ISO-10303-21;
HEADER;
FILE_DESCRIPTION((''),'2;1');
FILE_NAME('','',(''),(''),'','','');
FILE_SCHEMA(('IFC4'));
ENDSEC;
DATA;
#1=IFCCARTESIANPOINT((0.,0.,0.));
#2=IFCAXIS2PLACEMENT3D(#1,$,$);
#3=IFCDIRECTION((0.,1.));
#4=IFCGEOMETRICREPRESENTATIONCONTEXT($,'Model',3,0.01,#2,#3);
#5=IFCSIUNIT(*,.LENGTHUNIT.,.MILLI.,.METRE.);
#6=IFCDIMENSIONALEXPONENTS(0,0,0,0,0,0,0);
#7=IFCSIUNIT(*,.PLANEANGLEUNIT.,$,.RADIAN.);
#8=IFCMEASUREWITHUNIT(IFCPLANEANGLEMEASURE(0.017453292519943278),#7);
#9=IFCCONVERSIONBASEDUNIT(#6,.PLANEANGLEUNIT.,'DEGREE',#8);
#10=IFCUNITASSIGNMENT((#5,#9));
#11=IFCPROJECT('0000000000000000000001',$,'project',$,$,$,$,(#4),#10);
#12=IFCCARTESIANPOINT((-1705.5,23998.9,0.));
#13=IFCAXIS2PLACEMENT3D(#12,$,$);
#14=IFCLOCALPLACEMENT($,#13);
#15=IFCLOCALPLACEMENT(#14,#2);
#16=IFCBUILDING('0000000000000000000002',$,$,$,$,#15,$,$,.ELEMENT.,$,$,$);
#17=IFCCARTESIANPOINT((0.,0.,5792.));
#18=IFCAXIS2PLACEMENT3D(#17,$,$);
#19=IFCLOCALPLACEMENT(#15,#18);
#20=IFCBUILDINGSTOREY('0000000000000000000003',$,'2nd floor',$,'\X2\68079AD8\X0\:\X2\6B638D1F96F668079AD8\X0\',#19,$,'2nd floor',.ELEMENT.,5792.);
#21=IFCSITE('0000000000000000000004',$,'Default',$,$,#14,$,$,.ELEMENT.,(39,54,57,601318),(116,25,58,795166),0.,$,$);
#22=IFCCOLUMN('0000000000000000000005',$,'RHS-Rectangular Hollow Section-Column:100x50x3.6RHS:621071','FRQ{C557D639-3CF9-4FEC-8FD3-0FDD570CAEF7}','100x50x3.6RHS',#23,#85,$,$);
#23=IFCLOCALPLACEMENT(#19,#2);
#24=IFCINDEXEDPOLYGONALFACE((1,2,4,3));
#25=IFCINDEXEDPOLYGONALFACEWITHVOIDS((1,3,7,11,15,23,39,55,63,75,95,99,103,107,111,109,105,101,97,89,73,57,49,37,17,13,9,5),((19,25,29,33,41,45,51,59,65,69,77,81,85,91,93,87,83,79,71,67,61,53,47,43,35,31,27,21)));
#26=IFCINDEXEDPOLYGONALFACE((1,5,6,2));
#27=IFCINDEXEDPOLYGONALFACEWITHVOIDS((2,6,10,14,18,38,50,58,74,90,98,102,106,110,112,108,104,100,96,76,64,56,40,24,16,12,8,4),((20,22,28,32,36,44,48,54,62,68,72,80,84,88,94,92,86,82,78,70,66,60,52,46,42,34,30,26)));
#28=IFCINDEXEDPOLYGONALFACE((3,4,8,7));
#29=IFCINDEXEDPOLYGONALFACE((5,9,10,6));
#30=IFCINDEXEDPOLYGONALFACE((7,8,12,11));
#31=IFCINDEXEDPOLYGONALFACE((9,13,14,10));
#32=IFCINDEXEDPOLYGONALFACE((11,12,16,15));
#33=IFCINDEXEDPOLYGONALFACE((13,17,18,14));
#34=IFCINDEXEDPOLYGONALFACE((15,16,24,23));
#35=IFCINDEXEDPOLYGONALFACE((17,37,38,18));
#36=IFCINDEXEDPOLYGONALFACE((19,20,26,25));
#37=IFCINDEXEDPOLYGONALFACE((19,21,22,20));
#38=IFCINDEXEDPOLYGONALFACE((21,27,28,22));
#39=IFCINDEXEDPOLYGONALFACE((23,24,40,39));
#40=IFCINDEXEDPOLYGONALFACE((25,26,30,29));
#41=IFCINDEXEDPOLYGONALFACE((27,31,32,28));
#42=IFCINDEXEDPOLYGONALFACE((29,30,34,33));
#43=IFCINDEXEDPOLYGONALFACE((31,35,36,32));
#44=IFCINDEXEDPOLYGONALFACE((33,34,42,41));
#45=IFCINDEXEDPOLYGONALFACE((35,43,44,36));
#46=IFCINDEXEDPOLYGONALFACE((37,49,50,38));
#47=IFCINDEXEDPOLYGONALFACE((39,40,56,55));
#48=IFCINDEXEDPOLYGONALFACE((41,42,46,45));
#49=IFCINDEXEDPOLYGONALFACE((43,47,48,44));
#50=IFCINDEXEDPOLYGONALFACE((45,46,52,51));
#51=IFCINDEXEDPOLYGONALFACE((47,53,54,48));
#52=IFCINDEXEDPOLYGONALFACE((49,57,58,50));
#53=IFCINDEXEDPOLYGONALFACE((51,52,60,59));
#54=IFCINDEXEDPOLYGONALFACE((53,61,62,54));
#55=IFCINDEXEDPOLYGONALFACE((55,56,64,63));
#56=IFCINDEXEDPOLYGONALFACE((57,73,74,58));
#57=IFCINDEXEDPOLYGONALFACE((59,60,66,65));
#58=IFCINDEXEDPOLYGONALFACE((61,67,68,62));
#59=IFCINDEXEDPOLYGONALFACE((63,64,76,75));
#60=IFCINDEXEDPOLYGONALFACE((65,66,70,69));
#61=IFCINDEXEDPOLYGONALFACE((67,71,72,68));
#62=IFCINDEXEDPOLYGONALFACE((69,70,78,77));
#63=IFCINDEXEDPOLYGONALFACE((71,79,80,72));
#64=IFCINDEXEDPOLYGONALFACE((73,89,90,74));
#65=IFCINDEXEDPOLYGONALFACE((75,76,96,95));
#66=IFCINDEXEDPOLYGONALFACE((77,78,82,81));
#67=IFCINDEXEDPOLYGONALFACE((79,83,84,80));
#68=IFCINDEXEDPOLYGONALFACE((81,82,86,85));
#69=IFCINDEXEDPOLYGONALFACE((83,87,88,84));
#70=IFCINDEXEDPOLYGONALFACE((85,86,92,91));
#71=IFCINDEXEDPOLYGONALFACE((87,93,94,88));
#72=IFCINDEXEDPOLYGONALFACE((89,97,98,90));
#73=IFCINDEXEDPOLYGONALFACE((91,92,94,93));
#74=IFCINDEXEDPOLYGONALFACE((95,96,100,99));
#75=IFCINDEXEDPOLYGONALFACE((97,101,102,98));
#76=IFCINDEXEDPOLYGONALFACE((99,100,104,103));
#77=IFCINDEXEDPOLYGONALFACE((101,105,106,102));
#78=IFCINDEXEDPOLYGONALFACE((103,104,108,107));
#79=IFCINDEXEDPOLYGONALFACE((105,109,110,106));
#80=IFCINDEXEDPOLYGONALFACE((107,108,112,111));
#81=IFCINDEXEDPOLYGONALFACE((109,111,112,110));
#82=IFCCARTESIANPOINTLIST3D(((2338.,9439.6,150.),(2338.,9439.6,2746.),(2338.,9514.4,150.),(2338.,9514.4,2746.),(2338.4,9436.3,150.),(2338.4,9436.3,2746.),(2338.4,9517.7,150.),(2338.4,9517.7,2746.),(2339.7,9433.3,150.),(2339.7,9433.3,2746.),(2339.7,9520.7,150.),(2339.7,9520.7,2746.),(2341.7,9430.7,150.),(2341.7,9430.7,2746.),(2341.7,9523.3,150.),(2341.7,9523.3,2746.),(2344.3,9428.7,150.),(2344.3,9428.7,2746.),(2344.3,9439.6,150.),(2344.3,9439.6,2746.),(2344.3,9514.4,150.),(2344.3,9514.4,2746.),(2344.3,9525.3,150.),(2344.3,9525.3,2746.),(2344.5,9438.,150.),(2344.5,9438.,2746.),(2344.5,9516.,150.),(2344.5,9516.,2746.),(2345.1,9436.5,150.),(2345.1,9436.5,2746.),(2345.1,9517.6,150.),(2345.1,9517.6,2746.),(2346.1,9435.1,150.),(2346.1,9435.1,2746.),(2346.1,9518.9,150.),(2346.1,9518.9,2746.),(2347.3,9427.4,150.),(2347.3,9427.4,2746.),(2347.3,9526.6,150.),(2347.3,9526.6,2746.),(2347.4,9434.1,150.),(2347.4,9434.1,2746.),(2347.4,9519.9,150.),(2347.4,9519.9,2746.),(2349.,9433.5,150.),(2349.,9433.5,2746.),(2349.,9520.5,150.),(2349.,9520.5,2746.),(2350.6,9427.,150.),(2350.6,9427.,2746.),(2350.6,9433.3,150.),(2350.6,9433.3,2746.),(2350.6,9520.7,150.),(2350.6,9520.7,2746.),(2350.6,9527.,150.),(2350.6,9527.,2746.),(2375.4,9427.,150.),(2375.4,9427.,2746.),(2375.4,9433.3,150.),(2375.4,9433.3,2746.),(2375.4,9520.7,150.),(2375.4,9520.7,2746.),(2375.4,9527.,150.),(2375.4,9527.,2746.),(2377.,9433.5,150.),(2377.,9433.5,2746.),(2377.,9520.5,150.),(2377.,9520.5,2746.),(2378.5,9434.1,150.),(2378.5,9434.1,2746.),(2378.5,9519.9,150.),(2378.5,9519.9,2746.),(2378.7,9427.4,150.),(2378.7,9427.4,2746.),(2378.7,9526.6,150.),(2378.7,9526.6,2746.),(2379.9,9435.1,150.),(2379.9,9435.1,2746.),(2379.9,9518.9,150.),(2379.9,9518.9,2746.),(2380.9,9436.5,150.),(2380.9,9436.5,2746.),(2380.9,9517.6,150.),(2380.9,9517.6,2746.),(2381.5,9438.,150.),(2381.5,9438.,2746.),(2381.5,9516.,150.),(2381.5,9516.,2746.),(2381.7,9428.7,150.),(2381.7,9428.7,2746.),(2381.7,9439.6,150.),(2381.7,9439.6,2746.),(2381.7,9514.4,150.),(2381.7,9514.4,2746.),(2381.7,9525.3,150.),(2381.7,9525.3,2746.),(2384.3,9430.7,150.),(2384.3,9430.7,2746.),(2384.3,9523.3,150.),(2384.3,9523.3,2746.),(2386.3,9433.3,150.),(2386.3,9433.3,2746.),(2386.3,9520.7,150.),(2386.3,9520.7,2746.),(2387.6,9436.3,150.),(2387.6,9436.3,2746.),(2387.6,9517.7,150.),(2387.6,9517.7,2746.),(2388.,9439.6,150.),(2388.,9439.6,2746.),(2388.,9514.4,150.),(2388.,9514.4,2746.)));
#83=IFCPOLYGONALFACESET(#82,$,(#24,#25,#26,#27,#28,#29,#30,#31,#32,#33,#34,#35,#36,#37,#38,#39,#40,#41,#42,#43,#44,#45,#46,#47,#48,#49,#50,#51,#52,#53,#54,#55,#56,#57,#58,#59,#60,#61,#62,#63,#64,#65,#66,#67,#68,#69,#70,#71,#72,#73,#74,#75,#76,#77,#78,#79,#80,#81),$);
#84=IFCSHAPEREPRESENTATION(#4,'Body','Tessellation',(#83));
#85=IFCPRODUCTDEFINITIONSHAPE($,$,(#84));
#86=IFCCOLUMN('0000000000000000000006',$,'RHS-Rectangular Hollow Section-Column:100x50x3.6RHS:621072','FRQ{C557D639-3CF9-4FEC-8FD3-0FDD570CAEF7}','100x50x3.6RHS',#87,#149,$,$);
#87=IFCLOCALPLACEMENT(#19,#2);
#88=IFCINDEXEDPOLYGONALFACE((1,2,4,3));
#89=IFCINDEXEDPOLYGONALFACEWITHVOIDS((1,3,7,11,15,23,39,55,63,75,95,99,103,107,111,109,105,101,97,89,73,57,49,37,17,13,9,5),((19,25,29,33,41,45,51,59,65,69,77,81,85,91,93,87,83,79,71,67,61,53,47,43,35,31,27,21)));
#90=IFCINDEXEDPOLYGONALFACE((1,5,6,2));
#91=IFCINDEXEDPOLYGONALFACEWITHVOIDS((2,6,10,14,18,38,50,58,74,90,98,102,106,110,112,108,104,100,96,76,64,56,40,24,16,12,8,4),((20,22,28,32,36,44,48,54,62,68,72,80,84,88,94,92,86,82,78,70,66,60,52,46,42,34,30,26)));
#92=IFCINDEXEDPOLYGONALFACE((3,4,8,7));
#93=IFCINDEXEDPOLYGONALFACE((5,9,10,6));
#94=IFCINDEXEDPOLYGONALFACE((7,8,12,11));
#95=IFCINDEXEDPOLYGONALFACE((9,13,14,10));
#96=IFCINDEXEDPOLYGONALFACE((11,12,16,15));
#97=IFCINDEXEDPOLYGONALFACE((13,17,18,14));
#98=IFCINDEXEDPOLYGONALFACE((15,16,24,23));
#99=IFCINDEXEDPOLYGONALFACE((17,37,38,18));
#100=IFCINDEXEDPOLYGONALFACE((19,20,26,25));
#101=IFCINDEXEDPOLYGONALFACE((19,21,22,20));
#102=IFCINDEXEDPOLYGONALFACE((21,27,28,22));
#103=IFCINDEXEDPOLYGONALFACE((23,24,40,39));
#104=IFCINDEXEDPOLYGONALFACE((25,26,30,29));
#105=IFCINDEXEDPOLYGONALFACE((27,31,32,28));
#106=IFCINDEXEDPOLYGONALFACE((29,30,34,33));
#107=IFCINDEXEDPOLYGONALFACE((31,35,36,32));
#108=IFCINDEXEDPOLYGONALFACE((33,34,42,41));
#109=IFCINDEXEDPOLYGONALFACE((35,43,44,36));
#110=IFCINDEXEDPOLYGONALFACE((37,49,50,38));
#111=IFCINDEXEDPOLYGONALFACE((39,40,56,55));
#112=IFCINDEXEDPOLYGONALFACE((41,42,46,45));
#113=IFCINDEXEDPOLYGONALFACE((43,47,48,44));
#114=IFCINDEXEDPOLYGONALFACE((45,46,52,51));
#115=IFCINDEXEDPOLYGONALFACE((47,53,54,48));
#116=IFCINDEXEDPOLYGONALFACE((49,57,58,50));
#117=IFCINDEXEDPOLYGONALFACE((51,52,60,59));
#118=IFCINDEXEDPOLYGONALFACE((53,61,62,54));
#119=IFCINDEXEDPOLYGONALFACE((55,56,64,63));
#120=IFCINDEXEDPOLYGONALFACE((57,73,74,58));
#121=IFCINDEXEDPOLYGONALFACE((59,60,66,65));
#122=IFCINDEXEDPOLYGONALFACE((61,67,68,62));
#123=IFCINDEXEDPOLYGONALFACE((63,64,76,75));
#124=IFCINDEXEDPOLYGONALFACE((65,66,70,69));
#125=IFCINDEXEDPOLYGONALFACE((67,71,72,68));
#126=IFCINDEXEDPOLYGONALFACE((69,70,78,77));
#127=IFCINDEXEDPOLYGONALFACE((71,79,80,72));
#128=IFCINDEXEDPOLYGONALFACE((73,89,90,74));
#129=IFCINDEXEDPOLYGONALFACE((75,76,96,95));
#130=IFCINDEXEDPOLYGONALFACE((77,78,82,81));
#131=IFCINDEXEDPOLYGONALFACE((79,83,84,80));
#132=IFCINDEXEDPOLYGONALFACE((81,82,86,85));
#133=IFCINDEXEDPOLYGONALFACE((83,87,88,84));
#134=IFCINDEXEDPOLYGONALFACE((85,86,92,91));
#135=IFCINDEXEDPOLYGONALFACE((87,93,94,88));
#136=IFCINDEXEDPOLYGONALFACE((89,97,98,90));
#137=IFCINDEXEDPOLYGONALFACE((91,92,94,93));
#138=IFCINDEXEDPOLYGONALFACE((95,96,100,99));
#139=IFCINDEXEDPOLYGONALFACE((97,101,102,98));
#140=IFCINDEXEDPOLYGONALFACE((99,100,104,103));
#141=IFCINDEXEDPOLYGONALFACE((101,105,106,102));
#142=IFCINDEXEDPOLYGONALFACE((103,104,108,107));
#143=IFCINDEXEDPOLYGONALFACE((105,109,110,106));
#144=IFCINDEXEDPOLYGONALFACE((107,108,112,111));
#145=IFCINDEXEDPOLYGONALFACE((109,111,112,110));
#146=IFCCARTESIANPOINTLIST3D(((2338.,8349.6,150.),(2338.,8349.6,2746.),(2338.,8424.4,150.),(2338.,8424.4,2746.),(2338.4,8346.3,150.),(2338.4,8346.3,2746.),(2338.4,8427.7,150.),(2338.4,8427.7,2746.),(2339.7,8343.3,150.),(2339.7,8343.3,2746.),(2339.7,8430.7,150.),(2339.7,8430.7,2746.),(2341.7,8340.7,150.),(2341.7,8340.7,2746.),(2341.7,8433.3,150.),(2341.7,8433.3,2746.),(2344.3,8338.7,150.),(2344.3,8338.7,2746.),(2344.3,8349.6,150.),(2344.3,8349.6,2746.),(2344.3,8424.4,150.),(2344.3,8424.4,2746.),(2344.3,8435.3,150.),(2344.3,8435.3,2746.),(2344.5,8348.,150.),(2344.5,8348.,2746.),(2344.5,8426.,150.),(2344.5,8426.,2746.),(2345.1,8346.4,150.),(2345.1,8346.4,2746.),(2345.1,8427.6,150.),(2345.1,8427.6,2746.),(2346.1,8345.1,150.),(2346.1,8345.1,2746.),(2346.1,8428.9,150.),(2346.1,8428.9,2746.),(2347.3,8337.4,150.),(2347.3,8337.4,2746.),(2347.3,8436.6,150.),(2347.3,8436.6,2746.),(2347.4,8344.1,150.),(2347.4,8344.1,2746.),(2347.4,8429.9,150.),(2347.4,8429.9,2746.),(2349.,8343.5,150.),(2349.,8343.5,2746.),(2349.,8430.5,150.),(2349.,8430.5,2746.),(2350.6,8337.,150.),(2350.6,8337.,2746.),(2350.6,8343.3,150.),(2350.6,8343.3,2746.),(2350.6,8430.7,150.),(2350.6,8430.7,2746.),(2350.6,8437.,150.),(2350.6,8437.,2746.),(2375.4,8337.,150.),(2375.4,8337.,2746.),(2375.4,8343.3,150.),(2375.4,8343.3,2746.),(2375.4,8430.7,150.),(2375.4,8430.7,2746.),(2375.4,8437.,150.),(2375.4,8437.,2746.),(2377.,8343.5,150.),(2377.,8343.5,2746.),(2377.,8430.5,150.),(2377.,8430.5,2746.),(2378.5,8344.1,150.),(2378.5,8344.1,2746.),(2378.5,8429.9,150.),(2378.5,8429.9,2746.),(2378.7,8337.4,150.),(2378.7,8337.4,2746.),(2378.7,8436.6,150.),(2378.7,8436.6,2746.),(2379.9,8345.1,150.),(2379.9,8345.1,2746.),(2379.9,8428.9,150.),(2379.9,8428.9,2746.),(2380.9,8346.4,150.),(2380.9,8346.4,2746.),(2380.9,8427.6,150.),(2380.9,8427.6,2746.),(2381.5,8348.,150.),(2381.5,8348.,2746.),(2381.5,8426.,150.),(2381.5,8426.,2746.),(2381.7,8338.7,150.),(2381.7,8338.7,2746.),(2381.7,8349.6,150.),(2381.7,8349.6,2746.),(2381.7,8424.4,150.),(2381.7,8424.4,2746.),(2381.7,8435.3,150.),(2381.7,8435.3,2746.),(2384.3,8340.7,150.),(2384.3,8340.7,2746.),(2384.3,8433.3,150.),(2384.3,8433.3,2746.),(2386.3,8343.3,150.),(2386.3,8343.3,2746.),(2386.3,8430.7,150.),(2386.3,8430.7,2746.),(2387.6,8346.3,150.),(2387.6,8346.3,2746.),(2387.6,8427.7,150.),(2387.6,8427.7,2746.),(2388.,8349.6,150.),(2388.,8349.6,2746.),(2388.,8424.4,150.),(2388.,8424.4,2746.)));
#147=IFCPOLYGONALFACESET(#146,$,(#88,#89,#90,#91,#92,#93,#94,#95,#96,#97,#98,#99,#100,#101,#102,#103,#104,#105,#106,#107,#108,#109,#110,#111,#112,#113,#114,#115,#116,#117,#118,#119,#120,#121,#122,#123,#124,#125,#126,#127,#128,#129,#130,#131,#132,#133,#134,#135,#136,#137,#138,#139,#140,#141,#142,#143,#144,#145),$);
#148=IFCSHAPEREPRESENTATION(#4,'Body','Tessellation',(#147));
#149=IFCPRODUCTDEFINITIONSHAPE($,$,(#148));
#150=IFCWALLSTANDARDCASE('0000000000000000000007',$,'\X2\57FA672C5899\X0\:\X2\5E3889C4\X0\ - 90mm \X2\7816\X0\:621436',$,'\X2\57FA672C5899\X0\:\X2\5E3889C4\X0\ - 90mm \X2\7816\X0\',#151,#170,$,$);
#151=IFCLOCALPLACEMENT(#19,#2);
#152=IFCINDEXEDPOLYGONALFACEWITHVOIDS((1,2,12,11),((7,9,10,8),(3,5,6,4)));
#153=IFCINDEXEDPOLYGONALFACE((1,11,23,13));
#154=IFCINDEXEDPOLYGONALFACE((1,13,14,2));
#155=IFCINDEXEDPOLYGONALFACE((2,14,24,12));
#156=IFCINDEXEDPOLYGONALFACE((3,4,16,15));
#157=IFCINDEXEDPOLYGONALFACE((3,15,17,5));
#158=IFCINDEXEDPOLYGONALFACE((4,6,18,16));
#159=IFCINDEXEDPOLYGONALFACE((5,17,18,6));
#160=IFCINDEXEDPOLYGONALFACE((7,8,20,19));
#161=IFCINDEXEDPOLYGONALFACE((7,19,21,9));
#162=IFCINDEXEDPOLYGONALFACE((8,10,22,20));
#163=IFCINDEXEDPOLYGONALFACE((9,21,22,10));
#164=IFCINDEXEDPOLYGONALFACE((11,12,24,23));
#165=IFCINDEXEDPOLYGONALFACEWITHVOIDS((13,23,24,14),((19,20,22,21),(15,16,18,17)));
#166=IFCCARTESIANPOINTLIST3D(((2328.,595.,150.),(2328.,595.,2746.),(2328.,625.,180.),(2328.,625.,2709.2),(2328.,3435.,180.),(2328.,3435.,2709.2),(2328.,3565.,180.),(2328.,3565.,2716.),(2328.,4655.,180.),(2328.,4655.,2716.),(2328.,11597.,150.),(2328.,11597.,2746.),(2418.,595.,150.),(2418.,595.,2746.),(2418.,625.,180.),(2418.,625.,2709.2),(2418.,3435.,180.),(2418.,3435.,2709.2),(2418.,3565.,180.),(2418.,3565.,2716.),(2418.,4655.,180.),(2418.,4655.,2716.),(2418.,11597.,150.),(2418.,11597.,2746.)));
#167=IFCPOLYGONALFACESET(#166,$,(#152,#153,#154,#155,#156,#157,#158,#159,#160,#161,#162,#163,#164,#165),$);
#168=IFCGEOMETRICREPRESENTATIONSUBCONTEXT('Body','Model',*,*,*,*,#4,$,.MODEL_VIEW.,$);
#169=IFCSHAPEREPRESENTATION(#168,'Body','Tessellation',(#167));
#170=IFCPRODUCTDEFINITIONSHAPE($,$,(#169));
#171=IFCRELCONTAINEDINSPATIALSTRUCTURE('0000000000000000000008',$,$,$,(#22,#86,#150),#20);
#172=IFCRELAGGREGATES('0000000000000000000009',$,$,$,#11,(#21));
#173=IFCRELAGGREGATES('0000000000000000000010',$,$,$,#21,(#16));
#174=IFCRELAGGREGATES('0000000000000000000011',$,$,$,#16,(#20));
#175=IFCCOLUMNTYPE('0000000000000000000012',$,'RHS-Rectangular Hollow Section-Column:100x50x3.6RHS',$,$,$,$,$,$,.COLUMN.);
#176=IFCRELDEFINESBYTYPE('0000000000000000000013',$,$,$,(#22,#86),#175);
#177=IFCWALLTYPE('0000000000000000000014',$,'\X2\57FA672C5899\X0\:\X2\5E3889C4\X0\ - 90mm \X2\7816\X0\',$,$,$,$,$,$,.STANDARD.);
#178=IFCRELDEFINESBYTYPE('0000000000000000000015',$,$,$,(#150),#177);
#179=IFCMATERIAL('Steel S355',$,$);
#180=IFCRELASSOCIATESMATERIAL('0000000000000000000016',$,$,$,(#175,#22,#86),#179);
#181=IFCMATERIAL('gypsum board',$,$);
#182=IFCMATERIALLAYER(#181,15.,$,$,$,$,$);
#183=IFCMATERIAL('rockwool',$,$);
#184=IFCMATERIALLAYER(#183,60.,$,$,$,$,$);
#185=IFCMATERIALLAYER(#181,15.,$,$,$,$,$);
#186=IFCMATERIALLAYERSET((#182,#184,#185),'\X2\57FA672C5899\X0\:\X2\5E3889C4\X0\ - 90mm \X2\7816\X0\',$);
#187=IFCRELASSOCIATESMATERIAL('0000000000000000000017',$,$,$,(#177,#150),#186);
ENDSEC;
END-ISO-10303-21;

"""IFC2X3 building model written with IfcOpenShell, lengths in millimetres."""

from ifc_helpers import new_model, entity, si_unit, converted_unit, direction, frame, frame_2d, origin, origin_2d, place, context, subcontext, project, spatial, rectangle, hollow_rectangle, extrude, clip, halfspace, material, layer, layer_set, layer_usage, type_object, element, save


model = new_model("IFC2X3")

# Units and contexts
model_context = context("Model", 3, precision=0.01, world=origin(), true_north=direction((0.0, 1.0)))
body_context = subcontext(model_context, "Body", "Model", "MODEL_VIEW")
ifc_project = project(units=[si_unit("LENGTHUNIT", "METRE", prefix="MILLI"), converted_unit("PLANEANGLEUNIT", "DEGREE", entity("IfcPlaneAngleMeasure", 0.017453292519943278), si_unit("PLANEANGLEUNIT", "RADIAN"), dimensions=[0, 0, 0, 0, 0, 0, 0])], contexts=[model_context])

# Site, building, storey
site_placement = place(None, frame((-1705.5, 23998.9, 0.0)))
site = spatial("IfcSite", under=ifc_project, at=site_placement, Name="Default", CompositionType="ELEMENT", RefLatitude=(39, 54, 57, 601318), RefLongitude=(116, 25, 58, 795166), RefElevation=0.0)
building_placement = place(site_placement, origin())
building = spatial("IfcBuilding", under=site, at=building_placement, CompositionType="ELEMENT")
storey_placement = place(building_placement, frame((0.0, 0.0, 5792.0)))
storey = spatial("IfcBuildingStorey", under=building, at=storey_placement, Name="2nd floor", ObjectType="标高:正负零标高", LongName="2nd floor", CompositionType="ELEMENT", Elevation=5792.0)

# Columns
ifc_material_1 = material(Name="Steel S355")
column_type = type_object("IfcColumnType", Name="RHS-Rectangular Hollow Section-Column:100x50x3.6RHS", PredefinedType="COLUMN", material=ifc_material_1)
column_1_placement = place(storey_placement, frame((2363.0, 9477.0, 2746.0), z_axis=(0.0, 0.0, 1.0), x_axis=(-1.0, 0.0, 0.0)))
element("IfcColumn", 1, at=column_1_placement, inside=storey, type_object=column_type, material=ifc_material_1, Name="RHS-Rectangular Hollow Section-Column:100x50x3.6RHS:621071", Description="FRQ{C557D639-3CF9-4FEC-8FD3-0FDD570CAEF7}", ObjectType="100x50x3.6RHS", context=model_context, shape_type="Clipping", body=[
    clip(extrude(hollow_rectangle(XDim=50.0, YDim=100.0, WallThickness=6.3, InnerFilletRadius=6.3, OuterFilletRadius=12.6, at=origin_2d()), origin(), (0.0, 0.0, -1.0), 2651.9), halfspace(frame((2363.0, 9477.0, -2596.0), z_axis=(0.0, 0.0, 1.0), x_axis=(-1.0, 0.0, 0.0)), True)),
])
column_2_placement = place(storey_placement, frame((2363.0, 8387.0, 2746.0), z_axis=(0.0, 0.0, 1.0), x_axis=(-1.0, 0.0, 0.0)))
element("IfcColumn", 2, at=column_2_placement, inside=storey, type_object=column_type, material=ifc_material_1, Name="RHS-Rectangular Hollow Section-Column:100x50x3.6RHS:621072", Description="FRQ{C557D639-3CF9-4FEC-8FD3-0FDD570CAEF7}", ObjectType="100x50x3.6RHS", context=model_context, shape_type="Clipping", body=[
    clip(extrude(hollow_rectangle(XDim=50.0, YDim=100.0, WallThickness=6.3, InnerFilletRadius=6.3, OuterFilletRadius=12.6, at=origin_2d()), origin(), (0.0, 0.0, -1.0), 2651.9), halfspace(frame((2363.0, 8387.0, -2596.0), z_axis=(0.0, 0.0, 1.0), x_axis=(-1.0, 0.0, 0.0)), True)),
])

# Wall, openings
ifc_material_2 = material(Name="gypsum board")
ifc_layer_1 = layer(ifc_material_2, 15.0)
ifc_material_3 = material(Name="rockwool")
ifc_layer_2 = layer(ifc_material_3, 60.0)
ifc_layer_3 = layer(ifc_material_2, 15.0)
ifc_layer_set = layer_set([ifc_layer_1, ifc_layer_2, ifc_layer_3], Name="基本墙:常规 - 90mm 砖")
ifc_layer_usage = layer_usage(ifc_layer_set, "AXIS2", "NEGATIVE", 45.0)
wall_type = type_object("IfcWallType", Name="基本墙:常规 - 90mm 砖", PredefinedType="STANDARD", material=ifc_layer_set)
wall_placement = place(storey_placement, frame((2373.0, 11597.0, 150.0), z_axis=(0.0, 0.0, 1.0), x_axis=(0.0, -1.0, 0.0)))
wall = element("IfcWallStandardCase", 3, at=wall_placement, inside=storey, type_object=wall_type, material=ifc_layer_usage, Name="基本墙:常规 - 90mm 砖:621436", ObjectType="基本墙:常规 - 90mm 砖", context=body_context, shape_type="SweptSolid", body=[
    extrude(rectangle(XDim=11002.0, YDim=90.0, at=frame_2d((5501.0, 0.0), x_axis=(-1.0, 0.0))), origin(), (0.0, 0.0, 1.0), 2596.0),
])
opening_1_placement = place(wall_placement, origin())
element("IfcOpeningElement", 4, at=opening_1_placement, cuts=wall, ObjectType="Opening", context=body_context, shape_type="SweptSolid", body=[
    extrude(rectangle(XDim=2536.0, YDim=1090.0, at=frame_2d((0.0, 0.0), x_axis=(0.0, 1.0))), frame((7487.0, 45.0, 1298.0), z_axis=(0.0, -1.0, 0.0), x_axis=(-1.0, 0.0, 0.0)), (0.0, 0.0, 1.0), 90.0),
])
opening_2_placement = place(wall_placement, origin())
element("IfcOpeningElement", 5, at=opening_2_placement, cuts=wall, ObjectType="Opening", context=body_context, shape_type="SweptSolid", body=[
    extrude(rectangle(XDim=2529.2, YDim=2810.0, at=frame_2d((0.0, 0.0), x_axis=(0.0, 1.0))), frame((9567.0, 45.0, 1294.6), z_axis=(0.0, -1.0, 0.0), x_axis=(-1.0, 0.0, 0.0)), (0.0, 0.0, 1.0), 90.0),
])

save(model, "model.ifc")
